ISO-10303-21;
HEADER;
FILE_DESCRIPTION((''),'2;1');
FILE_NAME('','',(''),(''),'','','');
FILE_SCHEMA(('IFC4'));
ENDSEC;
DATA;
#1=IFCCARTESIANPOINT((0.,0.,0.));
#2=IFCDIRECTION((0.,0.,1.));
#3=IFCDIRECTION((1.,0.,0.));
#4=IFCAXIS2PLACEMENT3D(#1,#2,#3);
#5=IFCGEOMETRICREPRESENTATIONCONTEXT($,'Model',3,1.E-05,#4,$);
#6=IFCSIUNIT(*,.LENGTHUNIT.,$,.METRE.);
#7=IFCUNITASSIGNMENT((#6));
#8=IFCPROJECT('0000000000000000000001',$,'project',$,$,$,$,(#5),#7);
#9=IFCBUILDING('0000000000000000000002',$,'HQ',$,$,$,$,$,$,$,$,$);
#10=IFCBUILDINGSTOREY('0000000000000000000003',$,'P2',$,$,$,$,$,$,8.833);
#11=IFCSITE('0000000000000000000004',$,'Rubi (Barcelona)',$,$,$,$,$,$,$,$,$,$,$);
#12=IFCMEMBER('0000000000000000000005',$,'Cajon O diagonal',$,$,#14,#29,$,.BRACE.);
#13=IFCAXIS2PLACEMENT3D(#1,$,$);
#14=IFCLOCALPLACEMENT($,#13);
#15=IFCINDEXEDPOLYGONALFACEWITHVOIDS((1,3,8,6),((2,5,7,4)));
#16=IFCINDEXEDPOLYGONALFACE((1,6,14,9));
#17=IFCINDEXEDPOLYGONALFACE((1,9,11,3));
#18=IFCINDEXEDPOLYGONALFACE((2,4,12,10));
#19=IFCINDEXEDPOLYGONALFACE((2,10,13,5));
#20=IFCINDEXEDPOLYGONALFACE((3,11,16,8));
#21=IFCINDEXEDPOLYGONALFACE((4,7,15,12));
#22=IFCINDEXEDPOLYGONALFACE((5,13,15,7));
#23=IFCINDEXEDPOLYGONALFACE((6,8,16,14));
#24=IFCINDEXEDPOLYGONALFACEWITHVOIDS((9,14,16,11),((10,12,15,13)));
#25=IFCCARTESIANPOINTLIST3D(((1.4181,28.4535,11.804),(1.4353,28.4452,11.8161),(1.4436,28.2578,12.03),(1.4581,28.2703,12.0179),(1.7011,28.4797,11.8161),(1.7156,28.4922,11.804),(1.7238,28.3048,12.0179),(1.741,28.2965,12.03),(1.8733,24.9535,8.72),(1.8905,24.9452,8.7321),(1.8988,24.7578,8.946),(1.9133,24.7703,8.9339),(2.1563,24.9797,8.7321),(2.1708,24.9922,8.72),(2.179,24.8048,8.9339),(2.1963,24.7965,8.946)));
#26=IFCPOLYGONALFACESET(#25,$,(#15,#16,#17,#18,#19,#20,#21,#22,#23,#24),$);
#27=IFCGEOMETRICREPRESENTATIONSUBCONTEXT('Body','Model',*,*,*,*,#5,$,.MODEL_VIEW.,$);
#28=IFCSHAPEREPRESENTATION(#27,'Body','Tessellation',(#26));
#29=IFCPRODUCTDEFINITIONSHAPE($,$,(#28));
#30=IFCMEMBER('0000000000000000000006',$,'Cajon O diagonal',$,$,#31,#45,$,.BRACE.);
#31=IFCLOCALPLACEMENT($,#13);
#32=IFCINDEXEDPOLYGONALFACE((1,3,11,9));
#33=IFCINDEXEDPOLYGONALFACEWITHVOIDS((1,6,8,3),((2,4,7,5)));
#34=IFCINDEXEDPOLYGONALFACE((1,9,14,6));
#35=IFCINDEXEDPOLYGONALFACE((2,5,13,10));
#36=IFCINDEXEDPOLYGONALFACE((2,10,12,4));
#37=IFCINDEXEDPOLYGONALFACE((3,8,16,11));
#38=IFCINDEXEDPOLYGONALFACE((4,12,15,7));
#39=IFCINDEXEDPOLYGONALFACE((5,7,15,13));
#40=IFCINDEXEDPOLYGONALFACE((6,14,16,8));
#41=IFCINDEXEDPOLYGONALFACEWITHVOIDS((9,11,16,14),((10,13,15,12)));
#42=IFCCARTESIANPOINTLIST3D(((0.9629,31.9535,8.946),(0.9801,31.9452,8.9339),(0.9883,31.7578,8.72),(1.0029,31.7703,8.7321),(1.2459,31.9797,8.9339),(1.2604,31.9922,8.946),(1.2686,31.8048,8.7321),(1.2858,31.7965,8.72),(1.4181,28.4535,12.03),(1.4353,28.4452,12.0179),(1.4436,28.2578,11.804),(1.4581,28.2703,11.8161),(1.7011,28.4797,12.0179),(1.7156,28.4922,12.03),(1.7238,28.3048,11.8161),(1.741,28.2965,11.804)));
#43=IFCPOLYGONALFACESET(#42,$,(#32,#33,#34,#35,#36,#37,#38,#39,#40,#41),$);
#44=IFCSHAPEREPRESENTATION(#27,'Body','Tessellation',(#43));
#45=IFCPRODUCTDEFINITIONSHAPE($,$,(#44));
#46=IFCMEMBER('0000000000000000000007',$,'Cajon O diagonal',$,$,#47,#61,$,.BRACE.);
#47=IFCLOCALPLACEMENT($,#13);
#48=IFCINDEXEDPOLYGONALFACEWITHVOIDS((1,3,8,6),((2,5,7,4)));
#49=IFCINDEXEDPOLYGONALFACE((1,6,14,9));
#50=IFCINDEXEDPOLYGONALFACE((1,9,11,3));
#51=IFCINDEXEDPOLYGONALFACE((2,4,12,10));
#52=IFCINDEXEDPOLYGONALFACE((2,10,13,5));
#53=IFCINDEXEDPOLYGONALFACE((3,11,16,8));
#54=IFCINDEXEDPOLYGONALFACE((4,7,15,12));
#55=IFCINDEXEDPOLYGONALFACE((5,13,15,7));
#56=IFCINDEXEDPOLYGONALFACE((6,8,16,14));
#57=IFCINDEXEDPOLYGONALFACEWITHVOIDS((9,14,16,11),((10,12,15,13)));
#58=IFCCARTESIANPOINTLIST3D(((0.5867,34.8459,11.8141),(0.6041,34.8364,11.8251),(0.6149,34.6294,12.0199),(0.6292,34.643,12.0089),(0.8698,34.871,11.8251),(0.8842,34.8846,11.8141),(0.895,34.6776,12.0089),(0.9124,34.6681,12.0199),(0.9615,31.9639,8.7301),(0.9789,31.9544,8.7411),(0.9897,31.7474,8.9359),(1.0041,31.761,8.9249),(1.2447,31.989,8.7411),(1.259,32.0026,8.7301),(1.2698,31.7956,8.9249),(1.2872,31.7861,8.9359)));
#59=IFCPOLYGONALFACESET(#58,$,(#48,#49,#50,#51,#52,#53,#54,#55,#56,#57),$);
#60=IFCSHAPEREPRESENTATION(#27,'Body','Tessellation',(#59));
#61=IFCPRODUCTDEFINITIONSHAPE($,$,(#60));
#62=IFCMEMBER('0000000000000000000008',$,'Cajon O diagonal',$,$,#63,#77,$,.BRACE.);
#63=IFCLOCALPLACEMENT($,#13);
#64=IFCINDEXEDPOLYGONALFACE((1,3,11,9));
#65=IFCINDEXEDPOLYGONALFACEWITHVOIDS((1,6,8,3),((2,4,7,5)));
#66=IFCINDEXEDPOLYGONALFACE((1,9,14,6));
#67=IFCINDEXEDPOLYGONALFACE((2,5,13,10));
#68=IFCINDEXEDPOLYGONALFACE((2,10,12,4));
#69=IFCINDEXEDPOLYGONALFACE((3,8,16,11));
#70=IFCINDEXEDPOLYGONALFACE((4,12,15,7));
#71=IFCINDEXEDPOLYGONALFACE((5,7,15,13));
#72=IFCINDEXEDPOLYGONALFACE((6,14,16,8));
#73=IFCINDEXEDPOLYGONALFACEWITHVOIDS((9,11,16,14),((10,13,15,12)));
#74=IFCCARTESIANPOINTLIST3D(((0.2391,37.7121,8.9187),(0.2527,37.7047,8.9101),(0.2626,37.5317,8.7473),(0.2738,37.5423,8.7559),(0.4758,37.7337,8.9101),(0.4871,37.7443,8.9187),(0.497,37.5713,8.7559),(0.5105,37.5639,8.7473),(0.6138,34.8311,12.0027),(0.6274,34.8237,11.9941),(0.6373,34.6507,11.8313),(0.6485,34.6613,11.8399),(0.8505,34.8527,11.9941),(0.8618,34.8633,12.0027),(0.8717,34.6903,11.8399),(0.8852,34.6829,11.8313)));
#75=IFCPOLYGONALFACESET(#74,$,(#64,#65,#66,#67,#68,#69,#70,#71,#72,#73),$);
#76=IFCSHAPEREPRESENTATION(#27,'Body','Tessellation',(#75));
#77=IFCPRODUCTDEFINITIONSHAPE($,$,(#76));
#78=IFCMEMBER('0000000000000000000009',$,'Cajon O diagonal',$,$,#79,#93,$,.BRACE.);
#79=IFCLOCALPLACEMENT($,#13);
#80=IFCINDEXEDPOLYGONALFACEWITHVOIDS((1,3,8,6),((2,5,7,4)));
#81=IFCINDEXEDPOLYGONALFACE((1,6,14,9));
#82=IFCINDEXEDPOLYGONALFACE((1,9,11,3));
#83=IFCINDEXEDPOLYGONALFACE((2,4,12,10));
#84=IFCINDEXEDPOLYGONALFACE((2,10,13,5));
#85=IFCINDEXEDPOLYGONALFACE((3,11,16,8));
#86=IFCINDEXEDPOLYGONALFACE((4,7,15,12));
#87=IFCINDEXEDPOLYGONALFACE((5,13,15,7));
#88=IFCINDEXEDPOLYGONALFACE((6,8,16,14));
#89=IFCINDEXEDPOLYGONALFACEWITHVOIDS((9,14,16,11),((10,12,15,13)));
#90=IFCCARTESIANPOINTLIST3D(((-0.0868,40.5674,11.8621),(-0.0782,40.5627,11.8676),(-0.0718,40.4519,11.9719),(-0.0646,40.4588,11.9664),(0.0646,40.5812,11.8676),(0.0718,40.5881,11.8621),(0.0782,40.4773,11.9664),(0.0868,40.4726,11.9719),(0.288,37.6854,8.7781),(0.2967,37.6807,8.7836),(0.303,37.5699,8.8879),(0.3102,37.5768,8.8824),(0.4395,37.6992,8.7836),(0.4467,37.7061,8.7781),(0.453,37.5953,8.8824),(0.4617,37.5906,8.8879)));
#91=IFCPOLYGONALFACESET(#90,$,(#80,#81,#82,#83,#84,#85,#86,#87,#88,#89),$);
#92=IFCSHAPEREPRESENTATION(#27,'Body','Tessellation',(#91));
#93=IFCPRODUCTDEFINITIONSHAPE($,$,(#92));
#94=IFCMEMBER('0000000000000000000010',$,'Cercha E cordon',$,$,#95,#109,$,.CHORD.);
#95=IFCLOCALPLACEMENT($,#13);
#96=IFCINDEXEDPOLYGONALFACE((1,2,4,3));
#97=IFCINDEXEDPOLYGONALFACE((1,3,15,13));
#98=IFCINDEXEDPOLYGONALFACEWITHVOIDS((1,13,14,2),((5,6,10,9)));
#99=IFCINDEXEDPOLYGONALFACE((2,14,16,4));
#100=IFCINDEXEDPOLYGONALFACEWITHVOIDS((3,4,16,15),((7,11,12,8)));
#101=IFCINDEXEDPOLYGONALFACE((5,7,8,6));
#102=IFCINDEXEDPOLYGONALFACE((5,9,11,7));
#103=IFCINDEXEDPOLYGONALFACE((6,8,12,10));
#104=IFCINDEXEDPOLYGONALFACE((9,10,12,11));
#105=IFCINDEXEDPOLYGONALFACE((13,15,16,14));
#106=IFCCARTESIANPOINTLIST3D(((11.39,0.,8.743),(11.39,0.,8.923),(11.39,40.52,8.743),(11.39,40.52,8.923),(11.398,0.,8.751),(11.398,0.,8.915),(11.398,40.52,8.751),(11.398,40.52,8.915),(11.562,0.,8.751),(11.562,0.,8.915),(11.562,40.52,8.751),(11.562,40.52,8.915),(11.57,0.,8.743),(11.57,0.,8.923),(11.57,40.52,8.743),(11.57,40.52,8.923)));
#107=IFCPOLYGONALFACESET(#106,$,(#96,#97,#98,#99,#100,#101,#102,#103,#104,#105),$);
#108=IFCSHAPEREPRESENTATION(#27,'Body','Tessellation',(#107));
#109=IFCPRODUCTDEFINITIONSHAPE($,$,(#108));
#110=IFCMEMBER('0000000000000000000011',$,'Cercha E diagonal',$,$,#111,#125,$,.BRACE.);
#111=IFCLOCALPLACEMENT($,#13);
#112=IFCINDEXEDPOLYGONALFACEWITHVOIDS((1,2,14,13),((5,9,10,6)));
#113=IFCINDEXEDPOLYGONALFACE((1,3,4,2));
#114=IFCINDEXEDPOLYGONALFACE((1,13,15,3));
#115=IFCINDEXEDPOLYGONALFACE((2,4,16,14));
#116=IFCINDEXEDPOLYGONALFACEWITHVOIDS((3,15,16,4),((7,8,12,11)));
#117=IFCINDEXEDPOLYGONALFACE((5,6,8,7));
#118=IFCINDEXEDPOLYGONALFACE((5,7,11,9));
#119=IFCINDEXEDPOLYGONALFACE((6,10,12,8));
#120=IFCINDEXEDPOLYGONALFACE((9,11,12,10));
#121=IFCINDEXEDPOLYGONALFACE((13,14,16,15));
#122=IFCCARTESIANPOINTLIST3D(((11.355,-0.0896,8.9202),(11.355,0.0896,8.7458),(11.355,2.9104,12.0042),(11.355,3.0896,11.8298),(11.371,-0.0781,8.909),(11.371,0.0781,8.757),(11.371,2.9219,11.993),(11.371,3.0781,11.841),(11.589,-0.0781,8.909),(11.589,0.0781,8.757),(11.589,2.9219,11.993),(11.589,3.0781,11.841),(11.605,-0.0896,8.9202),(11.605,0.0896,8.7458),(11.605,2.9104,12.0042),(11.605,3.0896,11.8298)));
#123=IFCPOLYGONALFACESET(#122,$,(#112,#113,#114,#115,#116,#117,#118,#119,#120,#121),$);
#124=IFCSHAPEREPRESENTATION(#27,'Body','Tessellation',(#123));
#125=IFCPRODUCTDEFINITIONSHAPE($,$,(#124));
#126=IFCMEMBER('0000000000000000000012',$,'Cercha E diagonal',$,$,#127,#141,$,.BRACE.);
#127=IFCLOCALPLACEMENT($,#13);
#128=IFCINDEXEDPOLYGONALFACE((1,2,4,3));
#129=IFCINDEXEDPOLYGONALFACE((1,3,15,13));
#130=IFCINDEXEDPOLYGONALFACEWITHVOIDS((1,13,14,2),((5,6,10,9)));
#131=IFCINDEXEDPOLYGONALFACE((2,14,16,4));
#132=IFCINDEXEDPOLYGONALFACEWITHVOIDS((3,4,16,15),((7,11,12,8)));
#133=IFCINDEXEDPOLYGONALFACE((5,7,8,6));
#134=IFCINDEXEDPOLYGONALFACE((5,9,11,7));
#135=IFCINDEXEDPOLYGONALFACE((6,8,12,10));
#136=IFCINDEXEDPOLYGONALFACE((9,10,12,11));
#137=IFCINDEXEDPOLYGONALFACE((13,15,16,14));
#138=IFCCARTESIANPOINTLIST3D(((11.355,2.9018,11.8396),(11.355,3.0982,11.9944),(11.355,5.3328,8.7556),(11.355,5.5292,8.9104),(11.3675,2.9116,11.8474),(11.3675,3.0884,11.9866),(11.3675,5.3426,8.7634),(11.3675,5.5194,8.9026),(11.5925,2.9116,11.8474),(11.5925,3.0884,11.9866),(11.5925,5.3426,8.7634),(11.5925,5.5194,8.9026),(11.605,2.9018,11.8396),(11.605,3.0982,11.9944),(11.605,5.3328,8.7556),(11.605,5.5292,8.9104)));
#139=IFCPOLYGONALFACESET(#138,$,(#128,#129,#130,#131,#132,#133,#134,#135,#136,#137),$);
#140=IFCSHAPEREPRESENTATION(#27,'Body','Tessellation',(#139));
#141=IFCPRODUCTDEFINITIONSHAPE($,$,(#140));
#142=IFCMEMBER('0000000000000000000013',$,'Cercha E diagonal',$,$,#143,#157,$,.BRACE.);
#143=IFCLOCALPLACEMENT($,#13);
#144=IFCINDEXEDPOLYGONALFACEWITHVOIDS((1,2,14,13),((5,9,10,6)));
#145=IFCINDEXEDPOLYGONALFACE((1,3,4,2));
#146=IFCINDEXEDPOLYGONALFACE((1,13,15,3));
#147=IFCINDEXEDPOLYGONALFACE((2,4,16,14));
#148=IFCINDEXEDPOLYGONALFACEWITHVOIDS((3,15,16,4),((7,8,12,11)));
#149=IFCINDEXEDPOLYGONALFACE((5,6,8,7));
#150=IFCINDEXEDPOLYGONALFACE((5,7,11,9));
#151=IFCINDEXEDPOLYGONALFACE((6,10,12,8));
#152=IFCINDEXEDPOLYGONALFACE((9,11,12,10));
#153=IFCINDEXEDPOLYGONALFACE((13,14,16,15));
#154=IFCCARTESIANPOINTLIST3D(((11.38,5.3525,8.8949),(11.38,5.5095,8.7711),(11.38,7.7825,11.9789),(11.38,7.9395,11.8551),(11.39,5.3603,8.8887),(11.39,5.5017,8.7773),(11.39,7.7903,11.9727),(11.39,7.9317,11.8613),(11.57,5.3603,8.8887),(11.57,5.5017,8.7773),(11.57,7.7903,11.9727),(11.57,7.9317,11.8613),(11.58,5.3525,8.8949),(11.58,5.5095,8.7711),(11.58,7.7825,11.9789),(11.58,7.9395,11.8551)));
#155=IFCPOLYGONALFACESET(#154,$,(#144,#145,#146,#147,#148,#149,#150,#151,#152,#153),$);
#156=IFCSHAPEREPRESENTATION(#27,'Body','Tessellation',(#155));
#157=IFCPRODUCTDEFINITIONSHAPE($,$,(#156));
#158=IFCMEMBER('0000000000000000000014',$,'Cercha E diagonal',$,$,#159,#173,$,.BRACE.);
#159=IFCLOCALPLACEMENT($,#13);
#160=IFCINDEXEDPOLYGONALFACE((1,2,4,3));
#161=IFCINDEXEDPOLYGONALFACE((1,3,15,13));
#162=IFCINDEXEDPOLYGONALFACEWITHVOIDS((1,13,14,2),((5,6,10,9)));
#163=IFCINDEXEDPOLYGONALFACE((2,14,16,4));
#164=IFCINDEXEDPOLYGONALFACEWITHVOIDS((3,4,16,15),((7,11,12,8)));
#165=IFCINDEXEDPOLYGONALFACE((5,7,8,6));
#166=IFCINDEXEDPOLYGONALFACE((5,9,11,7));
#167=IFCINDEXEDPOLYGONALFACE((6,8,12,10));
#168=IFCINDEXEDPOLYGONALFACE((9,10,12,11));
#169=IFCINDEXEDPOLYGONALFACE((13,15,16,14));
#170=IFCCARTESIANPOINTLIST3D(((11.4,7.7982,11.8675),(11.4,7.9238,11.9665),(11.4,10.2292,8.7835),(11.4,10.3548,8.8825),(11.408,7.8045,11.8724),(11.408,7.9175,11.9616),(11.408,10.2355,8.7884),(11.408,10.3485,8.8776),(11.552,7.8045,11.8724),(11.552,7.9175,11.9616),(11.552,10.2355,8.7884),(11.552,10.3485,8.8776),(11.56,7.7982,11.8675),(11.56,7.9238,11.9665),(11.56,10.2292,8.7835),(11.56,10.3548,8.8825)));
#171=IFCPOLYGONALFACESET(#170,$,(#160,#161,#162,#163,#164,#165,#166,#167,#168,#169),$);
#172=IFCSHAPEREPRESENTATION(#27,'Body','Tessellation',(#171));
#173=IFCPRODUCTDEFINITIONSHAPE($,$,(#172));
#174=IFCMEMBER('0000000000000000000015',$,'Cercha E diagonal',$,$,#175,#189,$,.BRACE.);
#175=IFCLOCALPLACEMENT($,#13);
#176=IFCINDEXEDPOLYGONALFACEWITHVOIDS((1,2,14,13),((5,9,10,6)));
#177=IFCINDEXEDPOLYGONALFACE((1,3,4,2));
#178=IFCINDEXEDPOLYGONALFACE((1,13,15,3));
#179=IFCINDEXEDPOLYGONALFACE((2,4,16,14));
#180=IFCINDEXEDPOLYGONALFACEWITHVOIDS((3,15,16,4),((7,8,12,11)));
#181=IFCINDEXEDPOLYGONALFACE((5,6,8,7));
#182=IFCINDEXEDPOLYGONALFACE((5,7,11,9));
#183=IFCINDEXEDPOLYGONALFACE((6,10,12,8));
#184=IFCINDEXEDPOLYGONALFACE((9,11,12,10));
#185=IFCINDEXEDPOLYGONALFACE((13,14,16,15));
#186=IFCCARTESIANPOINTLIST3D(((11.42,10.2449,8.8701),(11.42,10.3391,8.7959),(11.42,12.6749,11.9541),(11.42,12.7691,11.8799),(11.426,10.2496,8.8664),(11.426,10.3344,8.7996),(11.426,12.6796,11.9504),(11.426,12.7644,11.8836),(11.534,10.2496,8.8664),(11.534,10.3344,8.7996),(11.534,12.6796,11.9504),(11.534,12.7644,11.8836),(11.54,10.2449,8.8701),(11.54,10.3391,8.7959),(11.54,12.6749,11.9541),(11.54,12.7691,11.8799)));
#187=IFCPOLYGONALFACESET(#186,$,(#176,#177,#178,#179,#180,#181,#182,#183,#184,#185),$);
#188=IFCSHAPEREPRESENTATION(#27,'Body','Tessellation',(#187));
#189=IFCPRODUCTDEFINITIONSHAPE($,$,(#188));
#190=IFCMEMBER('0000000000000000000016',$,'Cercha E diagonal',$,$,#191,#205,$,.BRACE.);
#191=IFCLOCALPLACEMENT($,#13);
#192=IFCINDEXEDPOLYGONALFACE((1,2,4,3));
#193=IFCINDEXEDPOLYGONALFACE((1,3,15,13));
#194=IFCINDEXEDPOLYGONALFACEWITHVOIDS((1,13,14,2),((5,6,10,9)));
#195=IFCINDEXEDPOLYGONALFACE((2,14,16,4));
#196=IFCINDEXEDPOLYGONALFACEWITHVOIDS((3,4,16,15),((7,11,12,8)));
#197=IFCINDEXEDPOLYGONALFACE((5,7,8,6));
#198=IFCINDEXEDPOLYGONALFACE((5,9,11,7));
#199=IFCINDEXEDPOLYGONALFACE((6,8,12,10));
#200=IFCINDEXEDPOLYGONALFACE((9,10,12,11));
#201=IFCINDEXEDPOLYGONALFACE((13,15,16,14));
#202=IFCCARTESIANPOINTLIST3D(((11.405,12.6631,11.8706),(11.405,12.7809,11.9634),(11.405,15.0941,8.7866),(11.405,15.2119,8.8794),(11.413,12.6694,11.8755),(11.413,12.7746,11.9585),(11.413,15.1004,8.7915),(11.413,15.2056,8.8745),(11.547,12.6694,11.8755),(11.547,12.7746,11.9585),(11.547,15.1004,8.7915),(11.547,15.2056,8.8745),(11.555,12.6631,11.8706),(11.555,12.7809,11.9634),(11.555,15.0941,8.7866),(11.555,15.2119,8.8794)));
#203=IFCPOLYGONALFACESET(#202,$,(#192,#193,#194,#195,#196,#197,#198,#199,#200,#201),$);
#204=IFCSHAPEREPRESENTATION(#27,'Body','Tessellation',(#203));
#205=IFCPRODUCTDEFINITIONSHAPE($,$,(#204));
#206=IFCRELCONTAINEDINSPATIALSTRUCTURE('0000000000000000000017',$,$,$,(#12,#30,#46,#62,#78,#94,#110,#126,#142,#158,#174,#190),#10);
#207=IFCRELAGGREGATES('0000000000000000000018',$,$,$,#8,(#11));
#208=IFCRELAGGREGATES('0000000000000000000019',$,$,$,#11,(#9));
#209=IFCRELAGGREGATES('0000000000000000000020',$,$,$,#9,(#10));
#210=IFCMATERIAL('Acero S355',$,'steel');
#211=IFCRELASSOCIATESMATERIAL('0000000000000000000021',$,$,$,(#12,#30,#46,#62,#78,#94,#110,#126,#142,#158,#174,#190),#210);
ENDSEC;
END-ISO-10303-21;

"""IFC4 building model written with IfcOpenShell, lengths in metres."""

from ifc_helpers import new_model, si_unit, frame, origin_with_axes, place, context, subcontext, project, spatial, hollow_rectangle, extrude, material, element, save


model = new_model("IFC4")

# Units and contexts
model_context = context("Model", 3, precision=1e-05, world=origin_with_axes())
body_context = subcontext(model_context, "Body", "Model", "MODEL_VIEW")
ifc_project = project(units=[si_unit("LENGTHUNIT", "METRE")], contexts=[model_context])

# Site, building, storey
site = spatial("IfcSite", under=ifc_project, Name="Rubi (Barcelona)")
building = spatial("IfcBuilding", under=site, Name="HQ")
storey = spatial("IfcBuildingStorey", under=building, Name="P2", Elevation=8.833)

# Members
ifc_material = material(Name="Acero S355", Category="steel")
member_1_placement = place(None, origin_with_axes())
element("IfcMember", 1, at=member_1_placement, inside=storey, material=ifc_material, Name="Cajon O diagonal", PredefinedType="BRACE", context=body_context, shape_type="SweptSolid", body=[
    extrude(hollow_rectangle(XDim=0.3, YDim=0.3, WallThickness=0.016), frame((2.0348, 24.875, 8.833), z_axis=(-0.097121, 0.746741, 0.657986), x_axis=(-0.991648, -0.128973, 0.0)), (0.0, 0.0, 1.0), 4.687),
])
member_2_placement = place(None, origin_with_axes())
element("IfcMember", 2, at=member_2_placement, inside=storey, material=ifc_material, Name="Cajon O diagonal", PredefinedType="BRACE", context=body_context, shape_type="SweptSolid", body=[
    extrude(hollow_rectangle(XDim=0.3, YDim=0.3, WallThickness=0.016), frame((1.1244, 31.875, 8.833), z_axis=(0.097121, -0.746741, 0.657986), x_axis=(0.991648, 0.128973, 0.0)), (0.0, 0.0, 1.0), 4.687),
])
member_3_placement = place(None, origin_with_axes())
element("IfcMember", 3, at=member_3_placement, inside=storey, material=ifc_material, Name="Cajon O diagonal", PredefinedType="BRACE", context=body_context, shape_type="SweptSolid", body=[
    extrude(hollow_rectangle(XDim=0.3, YDim=0.3, WallThickness=0.016), frame((1.1244, 31.875, 8.833), z_axis=(-0.088453, 0.680098, 0.727766), x_axis=(-0.991648, -0.128973, 0.0)), (0.0, 0.0, 1.0), 4.2376),
])
member_4_placement = place(None, origin_with_axes())
element("IfcMember", 4, at=member_4_placement, inside=storey, material=ifc_material, Name="Cajon O diagonal", PredefinedType="BRACE", context=body_context, shape_type="SweptSolid", body=[
    extrude(hollow_rectangle(XDim=0.25, YDim=0.25, WallThickness=0.0125), frame((0.3748, 37.638, 8.833), z_axis=(0.088437, -0.679973, 0.727885), x_axis=(0.991648, 0.128973, 0.0)), (0.0, 0.0, 1.0), 4.2369),
])
member_5_placement = place(None, origin_with_axes())
element("IfcMember", 5, at=member_5_placement, inside=storey, material=ifc_material, Name="Cajon O diagonal", PredefinedType="BRACE", context=body_context, shape_type="SweptSolid", body=[
    extrude(hollow_rectangle(XDim=0.16, YDim=0.16, WallThickness=0.008), frame((0.3748, 37.638, 8.833), z_axis=(-0.088453, 0.680098, 0.727766), x_axis=(-0.991648, -0.128973, 0.0)), (0.0, 0.0, 1.0), 4.2376),
])
member_6_placement = place(None, origin_with_axes())
element("IfcMember", 6, at=member_6_placement, inside=storey, material=ifc_material, Name="Cercha E cordon", PredefinedType="CHORD", context=body_context, shape_type="SweptSolid", body=[
    extrude(hollow_rectangle(XDim=0.18, YDim=0.18, WallThickness=0.008), frame((11.48, 0.0, 8.833), z_axis=(0.0, 1.0, 0.0), x_axis=(-1.0, 0.0, 0.0)), (0.0, 0.0, 1.0), 40.52),
])
member_7_placement = place(None, origin_with_axes())
element("IfcMember", 7, at=member_7_placement, inside=storey, material=ifc_material, Name="Cercha E diagonal", PredefinedType="BRACE", context=body_context, shape_type="SweptSolid", body=[
    extrude(hollow_rectangle(XDim=0.25, YDim=0.25, WallThickness=0.016), frame((11.48, 0.0, 8.833), z_axis=(0.0, 0.697278, 0.716801), x_axis=(-1.0, 0.0, 0.0)), (0.0, 0.0, 1.0), 4.3024),
])
member_8_placement = place(None, origin_with_axes())
element("IfcMember", 8, at=member_8_placement, inside=storey, material=ifc_material, Name="Cercha E diagonal", PredefinedType="BRACE", context=body_context, shape_type="SweptSolid", body=[
    extrude(hollow_rectangle(XDim=0.25, YDim=0.25, WallThickness=0.0125), frame((11.48, 5.431, 8.833), z_axis=(0.0, -0.619058, 0.785345), x_axis=(1.0, 0.0, 0.0)), (0.0, 0.0, 1.0), 3.9269),
])
member_9_placement = place(None, origin_with_axes())
element("IfcMember", 9, at=member_9_placement, inside=storey, material=ifc_material, Name="Cercha E diagonal", PredefinedType="BRACE", context=body_context, shape_type="SweptSolid", body=[
    extrude(hollow_rectangle(XDim=0.2, YDim=0.2, WallThickness=0.01), frame((11.48, 5.431, 8.833), z_axis=(0.0, 0.618901, 0.785469), x_axis=(-1.0, 0.0, 0.0)), (0.0, 0.0, 1.0), 3.9263),
])
member_10_placement = place(None, origin_with_axes())
element("IfcMember", 10, at=member_10_placement, inside=storey, material=ifc_material, Name="Cercha E diagonal", PredefinedType="BRACE", context=body_context, shape_type="SweptSolid", body=[
    extrude(hollow_rectangle(XDim=0.16, YDim=0.16, WallThickness=0.008), frame((11.48, 10.292, 8.833), z_axis=(0.0, -0.619058, 0.785345), x_axis=(1.0, 0.0, 0.0)), (0.0, 0.0, 1.0), 3.9269),
])
member_11_placement = place(None, origin_with_axes())
element("IfcMember", 11, at=member_11_placement, inside=storey, material=ifc_material, Name="Cercha E diagonal", PredefinedType="BRACE", context=body_context, shape_type="SweptSolid", body=[
    extrude(hollow_rectangle(XDim=0.12, YDim=0.12, WallThickness=0.006), frame((11.48, 10.292, 8.833), z_axis=(0.0, 0.618901, 0.785469), x_axis=(-1.0, 0.0, 0.0)), (0.0, 0.0, 1.0), 3.9263),
])
member_12_placement = place(None, origin_with_axes())
element("IfcMember", 12, at=member_12_placement, inside=storey, material=ifc_material, Name="Cercha E diagonal", PredefinedType="BRACE", context=body_context, shape_type="SweptSolid", body=[
    extrude(hollow_rectangle(XDim=0.15, YDim=0.15, WallThickness=0.008), frame((11.48, 15.153, 8.833), z_axis=(0.0, -0.619058, 0.785345), x_axis=(1.0, 0.0, 0.0)), (0.0, 0.0, 1.0), 3.9269),
])

save(model, "model.ifc")
